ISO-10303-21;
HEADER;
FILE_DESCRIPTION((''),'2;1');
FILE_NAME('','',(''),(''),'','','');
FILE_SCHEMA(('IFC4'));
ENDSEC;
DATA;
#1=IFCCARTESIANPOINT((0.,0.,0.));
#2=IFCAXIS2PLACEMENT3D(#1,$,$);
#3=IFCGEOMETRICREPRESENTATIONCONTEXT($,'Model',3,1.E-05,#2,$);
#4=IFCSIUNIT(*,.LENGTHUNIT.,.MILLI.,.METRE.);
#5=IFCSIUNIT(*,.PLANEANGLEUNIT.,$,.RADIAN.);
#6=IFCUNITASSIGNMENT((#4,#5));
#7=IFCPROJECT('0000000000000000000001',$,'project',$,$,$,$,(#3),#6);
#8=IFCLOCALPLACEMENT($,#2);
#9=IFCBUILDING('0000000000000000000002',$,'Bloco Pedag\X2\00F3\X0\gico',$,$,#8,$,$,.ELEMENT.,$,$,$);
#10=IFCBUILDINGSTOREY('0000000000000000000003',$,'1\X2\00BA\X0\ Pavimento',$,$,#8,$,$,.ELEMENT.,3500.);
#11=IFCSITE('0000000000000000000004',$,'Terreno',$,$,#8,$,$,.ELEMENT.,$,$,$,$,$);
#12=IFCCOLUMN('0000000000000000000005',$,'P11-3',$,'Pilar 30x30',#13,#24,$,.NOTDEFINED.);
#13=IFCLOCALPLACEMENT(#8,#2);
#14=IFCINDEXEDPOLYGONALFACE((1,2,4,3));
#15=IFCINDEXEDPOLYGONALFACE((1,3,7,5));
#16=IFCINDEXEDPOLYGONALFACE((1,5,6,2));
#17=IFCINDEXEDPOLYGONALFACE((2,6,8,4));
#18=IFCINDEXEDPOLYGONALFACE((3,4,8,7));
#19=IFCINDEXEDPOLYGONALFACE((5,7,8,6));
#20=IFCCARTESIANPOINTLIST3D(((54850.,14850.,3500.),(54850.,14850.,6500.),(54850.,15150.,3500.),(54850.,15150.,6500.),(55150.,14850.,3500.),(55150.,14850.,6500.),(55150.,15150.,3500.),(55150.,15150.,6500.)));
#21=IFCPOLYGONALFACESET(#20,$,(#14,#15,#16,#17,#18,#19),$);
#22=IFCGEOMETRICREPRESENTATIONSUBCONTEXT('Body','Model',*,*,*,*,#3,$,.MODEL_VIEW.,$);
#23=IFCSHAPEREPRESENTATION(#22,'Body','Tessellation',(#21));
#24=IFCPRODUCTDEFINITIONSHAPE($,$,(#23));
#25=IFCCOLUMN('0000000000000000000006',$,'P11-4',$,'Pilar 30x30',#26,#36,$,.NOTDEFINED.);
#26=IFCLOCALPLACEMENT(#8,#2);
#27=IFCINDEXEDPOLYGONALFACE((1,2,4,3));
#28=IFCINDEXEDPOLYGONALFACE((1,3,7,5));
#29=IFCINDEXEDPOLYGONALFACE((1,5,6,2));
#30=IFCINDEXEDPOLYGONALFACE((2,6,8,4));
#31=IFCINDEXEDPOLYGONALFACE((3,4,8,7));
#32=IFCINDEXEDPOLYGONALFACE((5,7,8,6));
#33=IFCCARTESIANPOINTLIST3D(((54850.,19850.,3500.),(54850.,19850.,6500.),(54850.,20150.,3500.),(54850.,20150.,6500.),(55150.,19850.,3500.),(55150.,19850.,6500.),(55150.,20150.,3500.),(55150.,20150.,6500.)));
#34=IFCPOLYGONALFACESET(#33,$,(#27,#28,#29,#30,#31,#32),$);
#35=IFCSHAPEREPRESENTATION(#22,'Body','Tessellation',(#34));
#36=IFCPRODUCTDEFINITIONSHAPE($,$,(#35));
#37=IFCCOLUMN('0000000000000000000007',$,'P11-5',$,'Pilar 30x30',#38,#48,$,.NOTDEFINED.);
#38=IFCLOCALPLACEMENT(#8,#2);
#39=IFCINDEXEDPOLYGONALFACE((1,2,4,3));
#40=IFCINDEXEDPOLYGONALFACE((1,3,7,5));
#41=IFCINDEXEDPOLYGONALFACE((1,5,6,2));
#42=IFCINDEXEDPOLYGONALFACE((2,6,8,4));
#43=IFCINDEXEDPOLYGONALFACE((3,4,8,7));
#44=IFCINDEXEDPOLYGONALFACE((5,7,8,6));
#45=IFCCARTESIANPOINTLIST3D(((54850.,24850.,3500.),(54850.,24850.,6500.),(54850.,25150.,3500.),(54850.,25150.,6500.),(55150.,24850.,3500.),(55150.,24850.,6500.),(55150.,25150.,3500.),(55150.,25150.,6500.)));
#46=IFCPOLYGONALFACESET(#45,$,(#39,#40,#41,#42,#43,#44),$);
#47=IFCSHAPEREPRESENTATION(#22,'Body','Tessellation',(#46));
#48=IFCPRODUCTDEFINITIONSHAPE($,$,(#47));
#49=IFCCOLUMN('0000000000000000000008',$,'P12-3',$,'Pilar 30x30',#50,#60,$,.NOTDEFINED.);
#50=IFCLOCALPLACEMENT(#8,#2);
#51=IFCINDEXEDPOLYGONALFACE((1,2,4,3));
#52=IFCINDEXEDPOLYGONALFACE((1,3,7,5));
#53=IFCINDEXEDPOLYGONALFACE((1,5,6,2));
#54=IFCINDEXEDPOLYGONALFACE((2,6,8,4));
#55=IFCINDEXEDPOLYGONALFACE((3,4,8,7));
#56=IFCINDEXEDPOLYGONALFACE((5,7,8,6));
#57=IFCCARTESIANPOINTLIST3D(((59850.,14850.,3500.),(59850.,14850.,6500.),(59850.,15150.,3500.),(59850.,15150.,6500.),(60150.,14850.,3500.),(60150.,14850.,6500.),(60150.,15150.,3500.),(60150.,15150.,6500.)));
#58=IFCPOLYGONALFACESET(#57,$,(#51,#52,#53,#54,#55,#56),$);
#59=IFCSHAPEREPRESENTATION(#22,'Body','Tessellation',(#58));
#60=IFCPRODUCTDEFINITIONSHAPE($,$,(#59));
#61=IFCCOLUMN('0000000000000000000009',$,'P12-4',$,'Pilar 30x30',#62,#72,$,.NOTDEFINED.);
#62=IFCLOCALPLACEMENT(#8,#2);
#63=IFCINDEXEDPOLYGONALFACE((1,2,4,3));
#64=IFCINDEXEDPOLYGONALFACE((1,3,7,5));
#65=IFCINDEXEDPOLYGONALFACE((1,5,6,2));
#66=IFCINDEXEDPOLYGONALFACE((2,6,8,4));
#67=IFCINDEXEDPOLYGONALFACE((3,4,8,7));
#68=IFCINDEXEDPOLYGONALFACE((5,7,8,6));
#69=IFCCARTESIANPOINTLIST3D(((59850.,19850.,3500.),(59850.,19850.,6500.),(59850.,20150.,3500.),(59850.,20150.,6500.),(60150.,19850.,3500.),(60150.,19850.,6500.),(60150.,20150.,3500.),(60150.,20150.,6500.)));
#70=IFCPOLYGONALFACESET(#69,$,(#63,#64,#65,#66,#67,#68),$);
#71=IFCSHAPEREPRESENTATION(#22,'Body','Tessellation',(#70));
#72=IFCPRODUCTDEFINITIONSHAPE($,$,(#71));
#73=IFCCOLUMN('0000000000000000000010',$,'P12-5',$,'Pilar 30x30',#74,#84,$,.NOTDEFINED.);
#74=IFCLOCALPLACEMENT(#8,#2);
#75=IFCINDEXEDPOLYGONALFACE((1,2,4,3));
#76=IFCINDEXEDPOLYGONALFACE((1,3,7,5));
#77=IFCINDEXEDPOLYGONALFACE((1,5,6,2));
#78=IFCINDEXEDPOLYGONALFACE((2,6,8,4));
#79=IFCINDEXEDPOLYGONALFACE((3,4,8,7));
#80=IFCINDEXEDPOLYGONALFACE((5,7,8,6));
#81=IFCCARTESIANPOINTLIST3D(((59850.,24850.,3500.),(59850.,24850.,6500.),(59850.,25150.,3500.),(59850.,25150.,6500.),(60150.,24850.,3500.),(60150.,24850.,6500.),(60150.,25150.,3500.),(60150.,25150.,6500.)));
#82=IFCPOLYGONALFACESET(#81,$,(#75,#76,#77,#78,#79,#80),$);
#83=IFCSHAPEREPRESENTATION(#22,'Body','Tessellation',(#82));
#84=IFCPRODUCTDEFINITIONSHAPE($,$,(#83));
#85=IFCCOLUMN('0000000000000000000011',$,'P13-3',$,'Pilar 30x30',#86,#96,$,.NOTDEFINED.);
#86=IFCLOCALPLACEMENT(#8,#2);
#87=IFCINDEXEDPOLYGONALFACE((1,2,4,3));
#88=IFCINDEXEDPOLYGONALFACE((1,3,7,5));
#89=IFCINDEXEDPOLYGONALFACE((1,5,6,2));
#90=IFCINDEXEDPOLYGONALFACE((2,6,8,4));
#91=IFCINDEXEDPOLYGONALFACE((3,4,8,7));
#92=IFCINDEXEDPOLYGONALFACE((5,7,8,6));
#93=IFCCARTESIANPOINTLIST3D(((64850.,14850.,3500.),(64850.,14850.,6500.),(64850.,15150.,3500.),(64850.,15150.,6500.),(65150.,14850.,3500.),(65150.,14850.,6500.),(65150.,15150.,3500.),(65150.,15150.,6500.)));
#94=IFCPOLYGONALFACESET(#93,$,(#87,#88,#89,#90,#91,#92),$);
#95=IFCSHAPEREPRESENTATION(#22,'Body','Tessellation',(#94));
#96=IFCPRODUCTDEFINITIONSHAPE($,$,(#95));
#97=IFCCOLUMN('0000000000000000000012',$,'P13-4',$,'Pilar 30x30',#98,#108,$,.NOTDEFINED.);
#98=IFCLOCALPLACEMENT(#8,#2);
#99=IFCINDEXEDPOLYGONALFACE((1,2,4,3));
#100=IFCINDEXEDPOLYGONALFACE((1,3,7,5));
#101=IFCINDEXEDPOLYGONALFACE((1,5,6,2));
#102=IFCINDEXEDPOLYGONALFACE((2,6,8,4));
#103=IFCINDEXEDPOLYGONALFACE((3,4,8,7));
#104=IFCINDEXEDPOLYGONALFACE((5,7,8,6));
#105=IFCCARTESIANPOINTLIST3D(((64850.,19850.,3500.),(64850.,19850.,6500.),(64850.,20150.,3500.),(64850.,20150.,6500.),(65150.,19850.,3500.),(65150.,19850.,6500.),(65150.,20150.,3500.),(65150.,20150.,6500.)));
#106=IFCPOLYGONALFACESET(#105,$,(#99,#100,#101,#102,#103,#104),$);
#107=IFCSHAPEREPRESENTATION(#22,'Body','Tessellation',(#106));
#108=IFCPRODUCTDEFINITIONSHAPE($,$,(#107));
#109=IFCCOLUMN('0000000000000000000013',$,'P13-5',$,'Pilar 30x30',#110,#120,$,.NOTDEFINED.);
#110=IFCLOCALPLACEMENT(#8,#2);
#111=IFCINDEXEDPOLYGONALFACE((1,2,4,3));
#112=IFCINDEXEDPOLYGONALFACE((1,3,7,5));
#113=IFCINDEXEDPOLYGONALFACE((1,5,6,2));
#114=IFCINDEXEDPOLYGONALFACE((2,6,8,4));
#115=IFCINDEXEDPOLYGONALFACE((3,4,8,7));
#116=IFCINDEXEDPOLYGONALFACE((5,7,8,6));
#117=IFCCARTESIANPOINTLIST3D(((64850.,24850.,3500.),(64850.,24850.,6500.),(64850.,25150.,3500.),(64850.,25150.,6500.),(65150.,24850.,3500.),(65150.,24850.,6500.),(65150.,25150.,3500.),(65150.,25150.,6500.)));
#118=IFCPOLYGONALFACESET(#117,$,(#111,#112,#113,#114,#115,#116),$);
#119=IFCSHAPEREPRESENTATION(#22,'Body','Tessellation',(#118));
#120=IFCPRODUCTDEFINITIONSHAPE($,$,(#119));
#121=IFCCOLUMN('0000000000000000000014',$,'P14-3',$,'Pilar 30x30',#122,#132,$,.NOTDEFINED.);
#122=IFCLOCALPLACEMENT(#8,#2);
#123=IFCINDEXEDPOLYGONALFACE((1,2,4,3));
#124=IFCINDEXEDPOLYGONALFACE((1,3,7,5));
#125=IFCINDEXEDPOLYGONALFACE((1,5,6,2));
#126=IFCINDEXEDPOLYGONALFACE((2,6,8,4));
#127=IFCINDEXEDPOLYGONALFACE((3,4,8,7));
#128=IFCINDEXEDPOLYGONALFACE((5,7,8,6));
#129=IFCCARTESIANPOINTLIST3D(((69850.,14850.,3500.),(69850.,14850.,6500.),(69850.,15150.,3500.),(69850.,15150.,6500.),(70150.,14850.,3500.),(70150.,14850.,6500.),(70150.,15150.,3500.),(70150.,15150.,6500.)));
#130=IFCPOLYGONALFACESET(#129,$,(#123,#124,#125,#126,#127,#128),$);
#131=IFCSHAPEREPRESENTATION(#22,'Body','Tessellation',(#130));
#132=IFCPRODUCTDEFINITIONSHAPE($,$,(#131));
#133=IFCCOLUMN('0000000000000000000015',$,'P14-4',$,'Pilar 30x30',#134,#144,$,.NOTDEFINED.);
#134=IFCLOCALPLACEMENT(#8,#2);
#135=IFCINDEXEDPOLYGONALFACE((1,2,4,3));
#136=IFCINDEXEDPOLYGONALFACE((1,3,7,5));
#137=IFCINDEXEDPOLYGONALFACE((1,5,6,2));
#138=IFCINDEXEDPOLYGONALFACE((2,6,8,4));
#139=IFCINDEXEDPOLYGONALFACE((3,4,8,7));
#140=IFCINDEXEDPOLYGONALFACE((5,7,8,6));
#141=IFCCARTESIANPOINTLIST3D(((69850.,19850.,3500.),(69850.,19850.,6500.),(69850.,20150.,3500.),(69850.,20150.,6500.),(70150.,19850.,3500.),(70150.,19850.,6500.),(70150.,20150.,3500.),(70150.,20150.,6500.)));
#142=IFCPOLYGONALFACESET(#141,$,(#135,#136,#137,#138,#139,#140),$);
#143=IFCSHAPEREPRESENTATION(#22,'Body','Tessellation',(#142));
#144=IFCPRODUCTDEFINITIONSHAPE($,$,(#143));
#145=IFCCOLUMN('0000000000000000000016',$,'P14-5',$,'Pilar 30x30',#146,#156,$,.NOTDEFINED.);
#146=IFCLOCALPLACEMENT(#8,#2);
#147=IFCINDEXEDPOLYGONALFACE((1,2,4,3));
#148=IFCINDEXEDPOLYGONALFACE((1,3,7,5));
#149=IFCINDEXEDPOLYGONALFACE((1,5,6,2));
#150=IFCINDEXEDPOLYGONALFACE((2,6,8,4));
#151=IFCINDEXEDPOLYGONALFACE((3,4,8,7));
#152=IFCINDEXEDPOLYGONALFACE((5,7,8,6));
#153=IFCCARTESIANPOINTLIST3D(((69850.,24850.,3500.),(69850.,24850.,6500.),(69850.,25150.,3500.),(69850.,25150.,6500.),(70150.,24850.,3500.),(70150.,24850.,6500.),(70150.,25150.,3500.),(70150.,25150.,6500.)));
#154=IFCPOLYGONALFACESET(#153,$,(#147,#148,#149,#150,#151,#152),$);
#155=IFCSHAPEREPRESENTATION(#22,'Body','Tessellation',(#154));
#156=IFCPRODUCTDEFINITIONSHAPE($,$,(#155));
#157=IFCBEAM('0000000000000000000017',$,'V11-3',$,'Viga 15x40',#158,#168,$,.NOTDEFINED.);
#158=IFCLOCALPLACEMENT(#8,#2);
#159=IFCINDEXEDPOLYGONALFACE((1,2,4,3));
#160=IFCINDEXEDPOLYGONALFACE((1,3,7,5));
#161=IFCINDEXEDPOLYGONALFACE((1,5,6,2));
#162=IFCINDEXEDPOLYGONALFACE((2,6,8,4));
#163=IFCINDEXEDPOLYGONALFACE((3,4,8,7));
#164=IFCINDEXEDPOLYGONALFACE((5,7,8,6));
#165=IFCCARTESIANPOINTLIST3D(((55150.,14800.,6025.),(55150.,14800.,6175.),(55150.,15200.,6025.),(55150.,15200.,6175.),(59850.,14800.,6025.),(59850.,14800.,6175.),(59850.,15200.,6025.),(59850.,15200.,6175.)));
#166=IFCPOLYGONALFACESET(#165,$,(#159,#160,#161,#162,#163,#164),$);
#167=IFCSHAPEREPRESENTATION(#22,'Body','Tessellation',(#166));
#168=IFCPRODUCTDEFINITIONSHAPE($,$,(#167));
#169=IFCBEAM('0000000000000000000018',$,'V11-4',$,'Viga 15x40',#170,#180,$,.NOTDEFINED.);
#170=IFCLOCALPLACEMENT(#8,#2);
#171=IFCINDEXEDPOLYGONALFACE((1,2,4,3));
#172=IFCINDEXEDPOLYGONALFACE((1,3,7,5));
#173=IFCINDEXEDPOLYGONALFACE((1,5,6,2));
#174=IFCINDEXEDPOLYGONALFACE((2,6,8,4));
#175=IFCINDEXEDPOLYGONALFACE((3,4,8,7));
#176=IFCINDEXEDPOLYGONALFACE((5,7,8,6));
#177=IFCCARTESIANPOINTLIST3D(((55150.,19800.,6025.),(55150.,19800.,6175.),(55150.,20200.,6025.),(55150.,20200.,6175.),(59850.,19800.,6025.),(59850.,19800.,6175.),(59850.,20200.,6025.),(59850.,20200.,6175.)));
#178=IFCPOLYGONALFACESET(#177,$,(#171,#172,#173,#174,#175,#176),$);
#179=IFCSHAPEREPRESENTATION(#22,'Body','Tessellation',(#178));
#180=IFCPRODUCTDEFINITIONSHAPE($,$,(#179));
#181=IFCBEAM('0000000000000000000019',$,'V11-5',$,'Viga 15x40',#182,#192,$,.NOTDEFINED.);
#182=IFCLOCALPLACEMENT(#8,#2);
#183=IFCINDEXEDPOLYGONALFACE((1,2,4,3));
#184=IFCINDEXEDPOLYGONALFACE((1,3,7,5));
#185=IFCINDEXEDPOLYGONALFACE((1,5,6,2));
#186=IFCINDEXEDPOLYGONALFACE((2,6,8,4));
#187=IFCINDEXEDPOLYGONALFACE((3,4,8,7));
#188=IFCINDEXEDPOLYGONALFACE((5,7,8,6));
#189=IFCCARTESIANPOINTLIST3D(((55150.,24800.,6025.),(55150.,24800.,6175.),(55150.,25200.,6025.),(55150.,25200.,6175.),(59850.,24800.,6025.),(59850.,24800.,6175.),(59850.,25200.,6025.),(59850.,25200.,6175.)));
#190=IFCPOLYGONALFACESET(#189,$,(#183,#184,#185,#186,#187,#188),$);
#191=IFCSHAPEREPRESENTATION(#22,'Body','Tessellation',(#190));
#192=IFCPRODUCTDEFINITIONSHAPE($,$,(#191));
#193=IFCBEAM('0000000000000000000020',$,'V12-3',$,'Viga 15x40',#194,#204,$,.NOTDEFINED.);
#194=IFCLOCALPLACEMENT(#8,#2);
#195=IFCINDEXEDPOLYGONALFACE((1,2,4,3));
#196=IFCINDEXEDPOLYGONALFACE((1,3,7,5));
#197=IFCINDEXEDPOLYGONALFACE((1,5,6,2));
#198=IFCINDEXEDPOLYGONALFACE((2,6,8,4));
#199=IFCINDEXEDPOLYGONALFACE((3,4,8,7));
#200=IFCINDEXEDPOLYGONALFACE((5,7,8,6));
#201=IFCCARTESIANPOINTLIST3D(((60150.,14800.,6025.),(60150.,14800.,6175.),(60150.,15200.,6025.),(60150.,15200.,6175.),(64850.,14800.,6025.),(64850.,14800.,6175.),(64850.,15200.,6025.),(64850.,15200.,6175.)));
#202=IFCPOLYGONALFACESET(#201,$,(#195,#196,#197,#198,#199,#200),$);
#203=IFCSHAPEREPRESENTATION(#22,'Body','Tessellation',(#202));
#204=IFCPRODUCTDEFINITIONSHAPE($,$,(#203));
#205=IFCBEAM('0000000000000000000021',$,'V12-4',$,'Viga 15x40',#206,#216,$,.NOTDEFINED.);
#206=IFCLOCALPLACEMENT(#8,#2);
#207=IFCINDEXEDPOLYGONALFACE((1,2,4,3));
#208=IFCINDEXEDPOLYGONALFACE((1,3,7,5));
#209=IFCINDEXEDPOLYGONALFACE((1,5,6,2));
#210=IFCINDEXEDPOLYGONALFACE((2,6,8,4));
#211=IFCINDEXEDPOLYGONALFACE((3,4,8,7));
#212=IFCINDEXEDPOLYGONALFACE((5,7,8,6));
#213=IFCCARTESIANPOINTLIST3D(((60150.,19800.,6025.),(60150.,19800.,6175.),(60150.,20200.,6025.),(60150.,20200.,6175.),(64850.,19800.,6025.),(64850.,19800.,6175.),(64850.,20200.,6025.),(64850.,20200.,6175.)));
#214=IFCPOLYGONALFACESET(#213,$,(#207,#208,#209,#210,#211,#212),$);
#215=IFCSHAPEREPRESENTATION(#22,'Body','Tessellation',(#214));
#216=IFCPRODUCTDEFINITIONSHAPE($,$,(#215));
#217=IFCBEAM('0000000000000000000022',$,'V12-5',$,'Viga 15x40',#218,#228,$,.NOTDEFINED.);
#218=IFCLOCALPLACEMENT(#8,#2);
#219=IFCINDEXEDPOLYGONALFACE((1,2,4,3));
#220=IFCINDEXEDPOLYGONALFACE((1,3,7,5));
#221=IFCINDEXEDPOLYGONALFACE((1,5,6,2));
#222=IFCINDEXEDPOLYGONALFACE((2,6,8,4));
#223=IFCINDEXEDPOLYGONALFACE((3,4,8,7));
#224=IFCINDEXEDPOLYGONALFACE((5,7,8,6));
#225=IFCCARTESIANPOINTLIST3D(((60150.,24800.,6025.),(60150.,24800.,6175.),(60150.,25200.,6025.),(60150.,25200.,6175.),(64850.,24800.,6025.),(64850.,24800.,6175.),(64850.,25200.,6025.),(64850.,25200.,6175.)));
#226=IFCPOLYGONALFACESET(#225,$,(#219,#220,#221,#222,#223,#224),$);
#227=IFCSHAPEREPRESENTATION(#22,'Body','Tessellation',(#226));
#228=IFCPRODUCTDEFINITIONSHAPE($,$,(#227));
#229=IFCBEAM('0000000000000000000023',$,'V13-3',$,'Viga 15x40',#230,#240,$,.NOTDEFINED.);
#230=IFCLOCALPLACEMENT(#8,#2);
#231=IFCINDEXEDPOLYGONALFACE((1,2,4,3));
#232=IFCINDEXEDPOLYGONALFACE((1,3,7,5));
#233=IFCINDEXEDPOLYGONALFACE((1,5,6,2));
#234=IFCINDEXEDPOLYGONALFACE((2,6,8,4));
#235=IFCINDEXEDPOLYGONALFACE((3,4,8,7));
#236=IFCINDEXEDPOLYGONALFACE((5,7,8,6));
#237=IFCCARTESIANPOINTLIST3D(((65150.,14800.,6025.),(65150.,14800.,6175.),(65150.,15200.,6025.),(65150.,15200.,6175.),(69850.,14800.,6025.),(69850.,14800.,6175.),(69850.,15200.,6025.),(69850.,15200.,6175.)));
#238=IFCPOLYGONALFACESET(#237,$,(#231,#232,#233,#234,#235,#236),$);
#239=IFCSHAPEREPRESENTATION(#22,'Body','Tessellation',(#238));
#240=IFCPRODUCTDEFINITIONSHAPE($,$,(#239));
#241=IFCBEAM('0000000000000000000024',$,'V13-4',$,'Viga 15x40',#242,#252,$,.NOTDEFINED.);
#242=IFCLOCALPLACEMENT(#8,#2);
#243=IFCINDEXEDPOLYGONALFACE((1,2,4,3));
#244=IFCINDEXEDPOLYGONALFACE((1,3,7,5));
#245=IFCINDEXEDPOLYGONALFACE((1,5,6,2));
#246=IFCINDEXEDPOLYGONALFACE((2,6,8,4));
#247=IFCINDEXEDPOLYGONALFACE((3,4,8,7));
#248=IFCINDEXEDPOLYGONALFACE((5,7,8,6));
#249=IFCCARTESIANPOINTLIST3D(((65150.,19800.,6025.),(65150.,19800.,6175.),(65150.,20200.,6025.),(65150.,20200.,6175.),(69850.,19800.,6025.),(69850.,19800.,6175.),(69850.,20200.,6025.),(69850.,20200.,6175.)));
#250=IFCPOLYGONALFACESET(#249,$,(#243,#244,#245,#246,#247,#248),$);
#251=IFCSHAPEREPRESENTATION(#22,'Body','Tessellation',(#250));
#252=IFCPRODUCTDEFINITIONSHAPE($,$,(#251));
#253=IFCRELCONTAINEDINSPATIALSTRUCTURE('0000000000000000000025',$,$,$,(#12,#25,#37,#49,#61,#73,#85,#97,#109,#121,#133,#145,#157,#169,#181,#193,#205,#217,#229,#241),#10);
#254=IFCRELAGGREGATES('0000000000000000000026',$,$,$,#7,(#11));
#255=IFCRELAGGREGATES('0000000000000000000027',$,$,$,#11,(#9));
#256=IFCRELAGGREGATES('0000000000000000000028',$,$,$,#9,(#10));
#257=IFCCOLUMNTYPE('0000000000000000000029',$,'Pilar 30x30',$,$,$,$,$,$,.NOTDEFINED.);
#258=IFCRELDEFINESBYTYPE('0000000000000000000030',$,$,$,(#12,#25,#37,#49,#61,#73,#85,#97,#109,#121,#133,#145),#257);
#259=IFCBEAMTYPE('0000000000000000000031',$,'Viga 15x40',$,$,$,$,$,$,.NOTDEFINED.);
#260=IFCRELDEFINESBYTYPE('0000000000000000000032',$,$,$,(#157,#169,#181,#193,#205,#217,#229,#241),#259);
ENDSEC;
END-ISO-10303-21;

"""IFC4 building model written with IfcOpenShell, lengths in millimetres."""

from ifc_helpers import new_model, si_unit, frame, origin, origin_2d, place, context, subcontext, project, spatial, rectangle, extrude, type_object, element, save


model = new_model("IFC4")

# Units and contexts
model_context = context("Model", 3, precision=1e-05, world=origin())
body_context = subcontext(model_context, "Body", "Model", "MODEL_VIEW")
ifc_project = project(units=[si_unit("LENGTHUNIT", "METRE", prefix="MILLI"), si_unit("PLANEANGLEUNIT", "RADIAN")], contexts=[model_context])

# Site, building, storey
placement = place(None, origin())
site = spatial("IfcSite", under=ifc_project, at=placement, Name="Terreno", CompositionType="ELEMENT")
building = spatial("IfcBuilding", under=site, at=placement, Name="Bloco Pedagógico", CompositionType="ELEMENT")
storey = spatial("IfcBuildingStorey", under=building, at=placement, Name="1º Pavimento", CompositionType="ELEMENT", Elevation=3500.0)

# Columns
column_type = type_object("IfcColumnType", Name="Pilar 30x30", PredefinedType="NOTDEFINED")
for number, where, z_axis, x_axis, name in (
    (1, (55000.0, 15000.0, 3500.0), (0.0, 0.0, 1.0), (1.0, 0.0, 0.0), "P11-3"),
    (2, (55000.0, 20000.0, 3500.0), (0.0, 0.0, 1.0), (1.0, 0.0, 0.0), "P11-4"),
    (3, (55000.0, 25000.0, 3500.0), (0.0, 0.0, 1.0), (1.0, 0.0, 0.0), "P11-5"),
    (4, (60000.0, 15000.0, 3500.0), (0.0, 0.0, 1.0), (1.0, 0.0, 0.0), "P12-3"),
    (5, (60000.0, 20000.0, 3500.0), (0.0, 0.0, 1.0), (1.0, 0.0, 0.0), "P12-4"),
    (6, (60000.0, 25000.0, 3500.0), (0.0, 0.0, 1.0), (1.0, 0.0, 0.0), "P12-5"),
    (7, (65000.0, 15000.0, 3500.0), (0.0, 0.0, 1.0), (1.0, 0.0, 0.0), "P13-3"),
    (8, (65000.0, 20000.0, 3500.0), (0.0, 0.0, 1.0), (1.0, 0.0, 0.0), "P13-4"),
    (9, (65000.0, 25000.0, 3500.0), (0.0, 0.0, 1.0), (1.0, 0.0, 0.0), "P13-5"),
    (10, (70000.0, 15000.0, 3500.0), (0.0, 0.0, 1.0), (1.0, 0.0, 0.0), "P14-3"),
    (11, (70000.0, 20000.0, 3500.0), (0.0, 0.0, 1.0), (1.0, 0.0, 0.0), "P14-4"),
    (12, (70000.0, 25000.0, 3500.0), (0.0, 0.0, 1.0), (1.0, 0.0, 0.0), "P14-5"),
):
    element("IfcColumn", number, at=place(None, frame(where, z_axis=z_axis, x_axis=x_axis)), inside=storey, type_object=column_type, Name=name, ObjectType="Pilar 30x30", PredefinedType="NOTDEFINED", context=body_context, shape_type="SweptSolid", body=[
        extrude(rectangle(XDim=300.0, YDim=300.0, at=origin_2d()), None, (0.0, 0.0, 1.0), 3000.0),
    ])

# Beams
beam_type = type_object("IfcBeamType", Name="Viga 15x40", PredefinedType="NOTDEFINED")
for number, where, z_axis, x_axis, name in (
    (13, (55150.0, 15000.0, 6100.0), (1.0, 0.0, 0.0), (0.0, 1.0, 0.0), "V11-3"),
    (14, (55150.0, 20000.0, 6100.0), (1.0, 0.0, 0.0), (0.0, 1.0, 0.0), "V11-4"),
    (15, (55150.0, 25000.0, 6100.0), (1.0, 0.0, 0.0), (0.0, 1.0, 0.0), "V11-5"),
    (16, (60150.0, 15000.0, 6100.0), (1.0, 0.0, 0.0), (0.0, 1.0, 0.0), "V12-3"),
    (17, (60150.0, 20000.0, 6100.0), (1.0, 0.0, 0.0), (0.0, 1.0, 0.0), "V12-4"),
    (18, (60150.0, 25000.0, 6100.0), (1.0, 0.0, 0.0), (0.0, 1.0, 0.0), "V12-5"),
    (19, (65150.0, 15000.0, 6100.0), (1.0, 0.0, 0.0), (0.0, 1.0, 0.0), "V13-3"),
    (20, (65150.0, 20000.0, 6100.0), (1.0, 0.0, 0.0), (0.0, 1.0, 0.0), "V13-4"),
):
    element("IfcBeam", number, at=place(None, frame(where, z_axis=z_axis, x_axis=x_axis)), inside=storey, type_object=beam_type, Name=name, ObjectType="Viga 15x40", PredefinedType="NOTDEFINED", context=body_context, shape_type="SweptSolid", body=[
        extrude(rectangle(XDim=400.0, YDim=150.0, at=origin_2d()), None, (0.0, 0.0, 1.0), 4700.0),
    ])

save(model, "model.ifc")
